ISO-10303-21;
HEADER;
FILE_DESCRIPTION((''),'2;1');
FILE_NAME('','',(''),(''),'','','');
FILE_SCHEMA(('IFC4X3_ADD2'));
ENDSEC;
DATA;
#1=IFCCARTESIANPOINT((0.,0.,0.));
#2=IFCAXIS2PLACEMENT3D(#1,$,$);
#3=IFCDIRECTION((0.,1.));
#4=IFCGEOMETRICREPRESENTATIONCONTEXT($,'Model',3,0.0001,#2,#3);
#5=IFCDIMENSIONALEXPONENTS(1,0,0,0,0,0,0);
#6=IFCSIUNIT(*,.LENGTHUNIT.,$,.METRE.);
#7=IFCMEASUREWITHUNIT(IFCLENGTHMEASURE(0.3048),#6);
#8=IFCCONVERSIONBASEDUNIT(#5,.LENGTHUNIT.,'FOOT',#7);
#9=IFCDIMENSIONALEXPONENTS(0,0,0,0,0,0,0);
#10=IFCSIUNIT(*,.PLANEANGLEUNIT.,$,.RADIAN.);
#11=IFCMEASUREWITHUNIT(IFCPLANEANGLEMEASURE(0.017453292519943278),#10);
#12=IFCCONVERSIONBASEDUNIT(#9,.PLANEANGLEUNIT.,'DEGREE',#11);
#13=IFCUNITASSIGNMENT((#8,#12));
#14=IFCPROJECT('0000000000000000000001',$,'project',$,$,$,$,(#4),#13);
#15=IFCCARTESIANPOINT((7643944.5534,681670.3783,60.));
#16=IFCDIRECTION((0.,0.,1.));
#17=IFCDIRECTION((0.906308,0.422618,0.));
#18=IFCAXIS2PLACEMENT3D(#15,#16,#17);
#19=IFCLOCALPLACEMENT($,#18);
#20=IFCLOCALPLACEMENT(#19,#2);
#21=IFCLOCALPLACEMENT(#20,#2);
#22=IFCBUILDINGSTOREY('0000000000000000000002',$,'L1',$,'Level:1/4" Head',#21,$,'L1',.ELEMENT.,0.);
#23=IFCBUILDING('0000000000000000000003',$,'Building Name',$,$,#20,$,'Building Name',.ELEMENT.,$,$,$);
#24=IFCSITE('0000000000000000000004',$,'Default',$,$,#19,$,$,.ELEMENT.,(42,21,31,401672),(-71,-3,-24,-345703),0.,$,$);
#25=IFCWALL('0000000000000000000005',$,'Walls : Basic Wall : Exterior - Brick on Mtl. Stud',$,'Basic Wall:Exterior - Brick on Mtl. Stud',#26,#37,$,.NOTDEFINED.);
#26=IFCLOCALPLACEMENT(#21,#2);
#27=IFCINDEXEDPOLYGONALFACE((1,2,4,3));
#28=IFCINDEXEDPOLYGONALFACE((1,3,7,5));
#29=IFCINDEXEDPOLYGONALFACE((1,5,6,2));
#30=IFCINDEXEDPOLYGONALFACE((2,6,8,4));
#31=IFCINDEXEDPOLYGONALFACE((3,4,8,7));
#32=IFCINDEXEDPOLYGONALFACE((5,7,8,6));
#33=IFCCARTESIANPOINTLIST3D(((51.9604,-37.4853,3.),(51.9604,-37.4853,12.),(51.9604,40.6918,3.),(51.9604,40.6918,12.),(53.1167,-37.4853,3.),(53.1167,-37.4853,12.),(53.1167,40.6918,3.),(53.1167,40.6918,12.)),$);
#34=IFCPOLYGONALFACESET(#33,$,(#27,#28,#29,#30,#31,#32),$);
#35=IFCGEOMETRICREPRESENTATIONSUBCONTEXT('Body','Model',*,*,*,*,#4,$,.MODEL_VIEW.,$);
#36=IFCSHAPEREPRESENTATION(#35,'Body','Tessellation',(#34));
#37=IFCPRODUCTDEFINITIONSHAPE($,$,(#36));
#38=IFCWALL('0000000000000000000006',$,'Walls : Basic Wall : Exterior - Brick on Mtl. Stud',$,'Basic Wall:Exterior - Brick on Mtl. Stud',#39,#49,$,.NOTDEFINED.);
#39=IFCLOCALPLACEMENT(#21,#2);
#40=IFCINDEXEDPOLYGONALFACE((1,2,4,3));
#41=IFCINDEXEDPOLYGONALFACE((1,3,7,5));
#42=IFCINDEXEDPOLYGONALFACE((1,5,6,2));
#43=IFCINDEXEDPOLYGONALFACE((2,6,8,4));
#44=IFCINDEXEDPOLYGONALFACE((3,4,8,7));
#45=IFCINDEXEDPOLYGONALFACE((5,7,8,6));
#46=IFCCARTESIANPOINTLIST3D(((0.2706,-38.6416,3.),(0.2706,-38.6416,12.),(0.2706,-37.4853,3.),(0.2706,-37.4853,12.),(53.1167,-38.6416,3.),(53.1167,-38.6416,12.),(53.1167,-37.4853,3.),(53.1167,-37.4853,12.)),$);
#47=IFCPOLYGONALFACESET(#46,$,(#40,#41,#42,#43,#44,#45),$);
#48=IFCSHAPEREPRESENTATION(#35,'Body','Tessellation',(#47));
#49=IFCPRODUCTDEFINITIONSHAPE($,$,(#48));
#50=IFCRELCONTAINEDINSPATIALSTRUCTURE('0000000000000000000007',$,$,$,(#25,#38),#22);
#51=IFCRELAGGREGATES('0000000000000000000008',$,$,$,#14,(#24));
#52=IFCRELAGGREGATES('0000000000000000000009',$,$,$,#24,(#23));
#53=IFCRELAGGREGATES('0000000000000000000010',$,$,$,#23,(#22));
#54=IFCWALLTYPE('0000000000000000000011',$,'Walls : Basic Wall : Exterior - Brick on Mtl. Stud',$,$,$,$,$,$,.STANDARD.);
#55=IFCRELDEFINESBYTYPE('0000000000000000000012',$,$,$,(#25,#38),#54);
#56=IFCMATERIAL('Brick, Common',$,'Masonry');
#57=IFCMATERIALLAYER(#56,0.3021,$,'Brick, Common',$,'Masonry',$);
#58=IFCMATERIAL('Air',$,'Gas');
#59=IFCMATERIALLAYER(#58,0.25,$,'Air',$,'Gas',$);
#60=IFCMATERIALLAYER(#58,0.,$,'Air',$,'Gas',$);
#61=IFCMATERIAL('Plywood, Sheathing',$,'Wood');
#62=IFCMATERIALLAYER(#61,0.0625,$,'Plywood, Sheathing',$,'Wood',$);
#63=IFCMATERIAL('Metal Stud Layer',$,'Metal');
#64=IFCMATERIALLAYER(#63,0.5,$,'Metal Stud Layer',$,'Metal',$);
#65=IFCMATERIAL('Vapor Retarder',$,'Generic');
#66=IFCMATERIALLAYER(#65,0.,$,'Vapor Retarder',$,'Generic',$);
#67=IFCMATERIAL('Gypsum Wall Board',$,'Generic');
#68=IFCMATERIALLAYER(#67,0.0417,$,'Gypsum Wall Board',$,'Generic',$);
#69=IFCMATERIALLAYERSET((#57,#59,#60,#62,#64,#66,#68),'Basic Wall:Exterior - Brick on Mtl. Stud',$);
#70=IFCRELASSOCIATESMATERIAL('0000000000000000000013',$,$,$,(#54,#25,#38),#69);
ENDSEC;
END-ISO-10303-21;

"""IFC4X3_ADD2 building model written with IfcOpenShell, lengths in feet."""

from ifc_helpers import new_model, entity, si_unit, converted_unit, direction, frame, frame_2d, origin, place, context, subcontext, project, spatial, rectangle, extrude, material, layer, layer_set, type_object, element, save


model = new_model("IFC4X3_ADD2")

# Units and contexts
model_context = context("Model", 3, precision=0.0001, world=origin(), true_north=direction((0.0, 1.0)))
body_context = subcontext(model_context, "Body", "Model", "MODEL_VIEW")
ifc_project = project(units=[converted_unit("LENGTHUNIT", "FOOT", entity("IfcLengthMeasure", 0.3048), si_unit("LENGTHUNIT", "METRE"), dimensions=[1, 0, 0, 0, 0, 0, 0]), converted_unit("PLANEANGLEUNIT", "DEGREE", entity("IfcPlaneAngleMeasure", 0.017453292519943278), si_unit("PLANEANGLEUNIT", "RADIAN"), dimensions=[0, 0, 0, 0, 0, 0, 0])], contexts=[model_context])

# Site, building, storey
site_placement = place(None, frame((7643944.5534, 681670.3783, 60.0), z_axis=(0.0, 0.0, 1.0), x_axis=(0.906308, 0.422618, 0.0)))
site = spatial("IfcSite", under=ifc_project, at=site_placement, Name="Default", CompositionType="ELEMENT", RefLatitude=(42, 21, 31, 401672), RefLongitude=(-71, -3, -24, -345703), RefElevation=0.0)
building_placement = place(site_placement, origin())
building = spatial("IfcBuilding", under=site, at=building_placement, Name="Building Name", LongName="Building Name", CompositionType="ELEMENT")
storey_placement = place(building_placement, origin())
storey = spatial("IfcBuildingStorey", under=building, at=storey_placement, Name="L1", ObjectType="Level:1/4\" Head", LongName="L1", CompositionType="ELEMENT", Elevation=0.0)

# Shared definitions
ifc_material_1 = material(Name="Plywood, Sheathing", Category="Wood")

# Walls
ifc_material_2 = material(Name="Air", Category="Gas")
ifc_material_3 = material(Name="Metal Stud Layer", Category="Metal")
ifc_material_4 = material(Name="Vapor Retarder", Category="Generic")
ifc_material_5 = material(Name="Gypsum Wall Board", Category="Generic")
ifc_material_6 = material(Name="Brick, Common", Category="Masonry")
ifc_layer_1 = layer(ifc_material_6, 0.3021, Name="Brick, Common", Category="Masonry")
ifc_layer_2 = layer(ifc_material_2, 0.25, Name="Air", Category="Gas")
ifc_layer_3 = layer(ifc_material_2, 0.0, Name="Air", Category="Gas")
ifc_layer_4 = layer(ifc_material_1, 0.0625, Name="Plywood, Sheathing", Category="Wood")
ifc_layer_5 = layer(ifc_material_3, 0.5, Name="Metal Stud Layer", Category="Metal")
ifc_layer_6 = layer(ifc_material_4, 0.0, Name="Vapor Retarder", Category="Generic")
ifc_layer_7 = layer(ifc_material_5, 0.0417, Name="Gypsum Wall Board", Category="Generic")
ifc_layer_set_1 = layer_set([ifc_layer_1, ifc_layer_2, ifc_layer_3, ifc_layer_4, ifc_layer_5, ifc_layer_6, ifc_layer_7], Name="Basic Wall:Exterior - Brick on Mtl. Stud")
wall_type_1 = type_object("IfcWallType", Name="Walls : Basic Wall : Exterior - Brick on Mtl. Stud", PredefinedType="STANDARD", material=ifc_layer_set_1)
wall_1_placement = place(storey_placement, frame((52.5386, 40.6918, 3.0), z_axis=(0.0, 0.0, 1.0), x_axis=(0.0, -1.0, 0.0)))
element("IfcWall", 1, at=wall_1_placement, inside=storey, type_object=wall_type_1, material=ifc_layer_set_1, Name="Walls : Basic Wall : Exterior - Brick on Mtl. Stud", ObjectType="Basic Wall:Exterior - Brick on Mtl. Stud", PredefinedType="NOTDEFINED", context=body_context, shape_type="SweptSolid", body=[
    extrude(rectangle(XDim=78.1771, YDim=1.1562, at=frame_2d((39.0885, 0.0), x_axis=(-1.0, 0.0))), origin(), (0.0, 0.0, 1.0), 9.0),
])
wall_2_placement = place(storey_placement, frame((53.1167, -38.0635, 3.0), z_axis=(0.0, 0.0, 1.0), x_axis=(-1.0, 0.0, 0.0)))
element("IfcWall", 2, at=wall_2_placement, inside=storey, type_object=wall_type_1, material=ifc_layer_set_1, Name="Walls : Basic Wall : Exterior - Brick on Mtl. Stud", ObjectType="Basic Wall:Exterior - Brick on Mtl. Stud", PredefinedType="NOTDEFINED", context=body_context, shape_type="SweptSolid", body=[
    extrude(rectangle(XDim=52.8461, YDim=1.1562, at=frame_2d((26.423, 0.0), x_axis=(-1.0, 0.0))), origin(), (0.0, 0.0, 1.0), 9.0),
])

save(model, "model.ifc")
